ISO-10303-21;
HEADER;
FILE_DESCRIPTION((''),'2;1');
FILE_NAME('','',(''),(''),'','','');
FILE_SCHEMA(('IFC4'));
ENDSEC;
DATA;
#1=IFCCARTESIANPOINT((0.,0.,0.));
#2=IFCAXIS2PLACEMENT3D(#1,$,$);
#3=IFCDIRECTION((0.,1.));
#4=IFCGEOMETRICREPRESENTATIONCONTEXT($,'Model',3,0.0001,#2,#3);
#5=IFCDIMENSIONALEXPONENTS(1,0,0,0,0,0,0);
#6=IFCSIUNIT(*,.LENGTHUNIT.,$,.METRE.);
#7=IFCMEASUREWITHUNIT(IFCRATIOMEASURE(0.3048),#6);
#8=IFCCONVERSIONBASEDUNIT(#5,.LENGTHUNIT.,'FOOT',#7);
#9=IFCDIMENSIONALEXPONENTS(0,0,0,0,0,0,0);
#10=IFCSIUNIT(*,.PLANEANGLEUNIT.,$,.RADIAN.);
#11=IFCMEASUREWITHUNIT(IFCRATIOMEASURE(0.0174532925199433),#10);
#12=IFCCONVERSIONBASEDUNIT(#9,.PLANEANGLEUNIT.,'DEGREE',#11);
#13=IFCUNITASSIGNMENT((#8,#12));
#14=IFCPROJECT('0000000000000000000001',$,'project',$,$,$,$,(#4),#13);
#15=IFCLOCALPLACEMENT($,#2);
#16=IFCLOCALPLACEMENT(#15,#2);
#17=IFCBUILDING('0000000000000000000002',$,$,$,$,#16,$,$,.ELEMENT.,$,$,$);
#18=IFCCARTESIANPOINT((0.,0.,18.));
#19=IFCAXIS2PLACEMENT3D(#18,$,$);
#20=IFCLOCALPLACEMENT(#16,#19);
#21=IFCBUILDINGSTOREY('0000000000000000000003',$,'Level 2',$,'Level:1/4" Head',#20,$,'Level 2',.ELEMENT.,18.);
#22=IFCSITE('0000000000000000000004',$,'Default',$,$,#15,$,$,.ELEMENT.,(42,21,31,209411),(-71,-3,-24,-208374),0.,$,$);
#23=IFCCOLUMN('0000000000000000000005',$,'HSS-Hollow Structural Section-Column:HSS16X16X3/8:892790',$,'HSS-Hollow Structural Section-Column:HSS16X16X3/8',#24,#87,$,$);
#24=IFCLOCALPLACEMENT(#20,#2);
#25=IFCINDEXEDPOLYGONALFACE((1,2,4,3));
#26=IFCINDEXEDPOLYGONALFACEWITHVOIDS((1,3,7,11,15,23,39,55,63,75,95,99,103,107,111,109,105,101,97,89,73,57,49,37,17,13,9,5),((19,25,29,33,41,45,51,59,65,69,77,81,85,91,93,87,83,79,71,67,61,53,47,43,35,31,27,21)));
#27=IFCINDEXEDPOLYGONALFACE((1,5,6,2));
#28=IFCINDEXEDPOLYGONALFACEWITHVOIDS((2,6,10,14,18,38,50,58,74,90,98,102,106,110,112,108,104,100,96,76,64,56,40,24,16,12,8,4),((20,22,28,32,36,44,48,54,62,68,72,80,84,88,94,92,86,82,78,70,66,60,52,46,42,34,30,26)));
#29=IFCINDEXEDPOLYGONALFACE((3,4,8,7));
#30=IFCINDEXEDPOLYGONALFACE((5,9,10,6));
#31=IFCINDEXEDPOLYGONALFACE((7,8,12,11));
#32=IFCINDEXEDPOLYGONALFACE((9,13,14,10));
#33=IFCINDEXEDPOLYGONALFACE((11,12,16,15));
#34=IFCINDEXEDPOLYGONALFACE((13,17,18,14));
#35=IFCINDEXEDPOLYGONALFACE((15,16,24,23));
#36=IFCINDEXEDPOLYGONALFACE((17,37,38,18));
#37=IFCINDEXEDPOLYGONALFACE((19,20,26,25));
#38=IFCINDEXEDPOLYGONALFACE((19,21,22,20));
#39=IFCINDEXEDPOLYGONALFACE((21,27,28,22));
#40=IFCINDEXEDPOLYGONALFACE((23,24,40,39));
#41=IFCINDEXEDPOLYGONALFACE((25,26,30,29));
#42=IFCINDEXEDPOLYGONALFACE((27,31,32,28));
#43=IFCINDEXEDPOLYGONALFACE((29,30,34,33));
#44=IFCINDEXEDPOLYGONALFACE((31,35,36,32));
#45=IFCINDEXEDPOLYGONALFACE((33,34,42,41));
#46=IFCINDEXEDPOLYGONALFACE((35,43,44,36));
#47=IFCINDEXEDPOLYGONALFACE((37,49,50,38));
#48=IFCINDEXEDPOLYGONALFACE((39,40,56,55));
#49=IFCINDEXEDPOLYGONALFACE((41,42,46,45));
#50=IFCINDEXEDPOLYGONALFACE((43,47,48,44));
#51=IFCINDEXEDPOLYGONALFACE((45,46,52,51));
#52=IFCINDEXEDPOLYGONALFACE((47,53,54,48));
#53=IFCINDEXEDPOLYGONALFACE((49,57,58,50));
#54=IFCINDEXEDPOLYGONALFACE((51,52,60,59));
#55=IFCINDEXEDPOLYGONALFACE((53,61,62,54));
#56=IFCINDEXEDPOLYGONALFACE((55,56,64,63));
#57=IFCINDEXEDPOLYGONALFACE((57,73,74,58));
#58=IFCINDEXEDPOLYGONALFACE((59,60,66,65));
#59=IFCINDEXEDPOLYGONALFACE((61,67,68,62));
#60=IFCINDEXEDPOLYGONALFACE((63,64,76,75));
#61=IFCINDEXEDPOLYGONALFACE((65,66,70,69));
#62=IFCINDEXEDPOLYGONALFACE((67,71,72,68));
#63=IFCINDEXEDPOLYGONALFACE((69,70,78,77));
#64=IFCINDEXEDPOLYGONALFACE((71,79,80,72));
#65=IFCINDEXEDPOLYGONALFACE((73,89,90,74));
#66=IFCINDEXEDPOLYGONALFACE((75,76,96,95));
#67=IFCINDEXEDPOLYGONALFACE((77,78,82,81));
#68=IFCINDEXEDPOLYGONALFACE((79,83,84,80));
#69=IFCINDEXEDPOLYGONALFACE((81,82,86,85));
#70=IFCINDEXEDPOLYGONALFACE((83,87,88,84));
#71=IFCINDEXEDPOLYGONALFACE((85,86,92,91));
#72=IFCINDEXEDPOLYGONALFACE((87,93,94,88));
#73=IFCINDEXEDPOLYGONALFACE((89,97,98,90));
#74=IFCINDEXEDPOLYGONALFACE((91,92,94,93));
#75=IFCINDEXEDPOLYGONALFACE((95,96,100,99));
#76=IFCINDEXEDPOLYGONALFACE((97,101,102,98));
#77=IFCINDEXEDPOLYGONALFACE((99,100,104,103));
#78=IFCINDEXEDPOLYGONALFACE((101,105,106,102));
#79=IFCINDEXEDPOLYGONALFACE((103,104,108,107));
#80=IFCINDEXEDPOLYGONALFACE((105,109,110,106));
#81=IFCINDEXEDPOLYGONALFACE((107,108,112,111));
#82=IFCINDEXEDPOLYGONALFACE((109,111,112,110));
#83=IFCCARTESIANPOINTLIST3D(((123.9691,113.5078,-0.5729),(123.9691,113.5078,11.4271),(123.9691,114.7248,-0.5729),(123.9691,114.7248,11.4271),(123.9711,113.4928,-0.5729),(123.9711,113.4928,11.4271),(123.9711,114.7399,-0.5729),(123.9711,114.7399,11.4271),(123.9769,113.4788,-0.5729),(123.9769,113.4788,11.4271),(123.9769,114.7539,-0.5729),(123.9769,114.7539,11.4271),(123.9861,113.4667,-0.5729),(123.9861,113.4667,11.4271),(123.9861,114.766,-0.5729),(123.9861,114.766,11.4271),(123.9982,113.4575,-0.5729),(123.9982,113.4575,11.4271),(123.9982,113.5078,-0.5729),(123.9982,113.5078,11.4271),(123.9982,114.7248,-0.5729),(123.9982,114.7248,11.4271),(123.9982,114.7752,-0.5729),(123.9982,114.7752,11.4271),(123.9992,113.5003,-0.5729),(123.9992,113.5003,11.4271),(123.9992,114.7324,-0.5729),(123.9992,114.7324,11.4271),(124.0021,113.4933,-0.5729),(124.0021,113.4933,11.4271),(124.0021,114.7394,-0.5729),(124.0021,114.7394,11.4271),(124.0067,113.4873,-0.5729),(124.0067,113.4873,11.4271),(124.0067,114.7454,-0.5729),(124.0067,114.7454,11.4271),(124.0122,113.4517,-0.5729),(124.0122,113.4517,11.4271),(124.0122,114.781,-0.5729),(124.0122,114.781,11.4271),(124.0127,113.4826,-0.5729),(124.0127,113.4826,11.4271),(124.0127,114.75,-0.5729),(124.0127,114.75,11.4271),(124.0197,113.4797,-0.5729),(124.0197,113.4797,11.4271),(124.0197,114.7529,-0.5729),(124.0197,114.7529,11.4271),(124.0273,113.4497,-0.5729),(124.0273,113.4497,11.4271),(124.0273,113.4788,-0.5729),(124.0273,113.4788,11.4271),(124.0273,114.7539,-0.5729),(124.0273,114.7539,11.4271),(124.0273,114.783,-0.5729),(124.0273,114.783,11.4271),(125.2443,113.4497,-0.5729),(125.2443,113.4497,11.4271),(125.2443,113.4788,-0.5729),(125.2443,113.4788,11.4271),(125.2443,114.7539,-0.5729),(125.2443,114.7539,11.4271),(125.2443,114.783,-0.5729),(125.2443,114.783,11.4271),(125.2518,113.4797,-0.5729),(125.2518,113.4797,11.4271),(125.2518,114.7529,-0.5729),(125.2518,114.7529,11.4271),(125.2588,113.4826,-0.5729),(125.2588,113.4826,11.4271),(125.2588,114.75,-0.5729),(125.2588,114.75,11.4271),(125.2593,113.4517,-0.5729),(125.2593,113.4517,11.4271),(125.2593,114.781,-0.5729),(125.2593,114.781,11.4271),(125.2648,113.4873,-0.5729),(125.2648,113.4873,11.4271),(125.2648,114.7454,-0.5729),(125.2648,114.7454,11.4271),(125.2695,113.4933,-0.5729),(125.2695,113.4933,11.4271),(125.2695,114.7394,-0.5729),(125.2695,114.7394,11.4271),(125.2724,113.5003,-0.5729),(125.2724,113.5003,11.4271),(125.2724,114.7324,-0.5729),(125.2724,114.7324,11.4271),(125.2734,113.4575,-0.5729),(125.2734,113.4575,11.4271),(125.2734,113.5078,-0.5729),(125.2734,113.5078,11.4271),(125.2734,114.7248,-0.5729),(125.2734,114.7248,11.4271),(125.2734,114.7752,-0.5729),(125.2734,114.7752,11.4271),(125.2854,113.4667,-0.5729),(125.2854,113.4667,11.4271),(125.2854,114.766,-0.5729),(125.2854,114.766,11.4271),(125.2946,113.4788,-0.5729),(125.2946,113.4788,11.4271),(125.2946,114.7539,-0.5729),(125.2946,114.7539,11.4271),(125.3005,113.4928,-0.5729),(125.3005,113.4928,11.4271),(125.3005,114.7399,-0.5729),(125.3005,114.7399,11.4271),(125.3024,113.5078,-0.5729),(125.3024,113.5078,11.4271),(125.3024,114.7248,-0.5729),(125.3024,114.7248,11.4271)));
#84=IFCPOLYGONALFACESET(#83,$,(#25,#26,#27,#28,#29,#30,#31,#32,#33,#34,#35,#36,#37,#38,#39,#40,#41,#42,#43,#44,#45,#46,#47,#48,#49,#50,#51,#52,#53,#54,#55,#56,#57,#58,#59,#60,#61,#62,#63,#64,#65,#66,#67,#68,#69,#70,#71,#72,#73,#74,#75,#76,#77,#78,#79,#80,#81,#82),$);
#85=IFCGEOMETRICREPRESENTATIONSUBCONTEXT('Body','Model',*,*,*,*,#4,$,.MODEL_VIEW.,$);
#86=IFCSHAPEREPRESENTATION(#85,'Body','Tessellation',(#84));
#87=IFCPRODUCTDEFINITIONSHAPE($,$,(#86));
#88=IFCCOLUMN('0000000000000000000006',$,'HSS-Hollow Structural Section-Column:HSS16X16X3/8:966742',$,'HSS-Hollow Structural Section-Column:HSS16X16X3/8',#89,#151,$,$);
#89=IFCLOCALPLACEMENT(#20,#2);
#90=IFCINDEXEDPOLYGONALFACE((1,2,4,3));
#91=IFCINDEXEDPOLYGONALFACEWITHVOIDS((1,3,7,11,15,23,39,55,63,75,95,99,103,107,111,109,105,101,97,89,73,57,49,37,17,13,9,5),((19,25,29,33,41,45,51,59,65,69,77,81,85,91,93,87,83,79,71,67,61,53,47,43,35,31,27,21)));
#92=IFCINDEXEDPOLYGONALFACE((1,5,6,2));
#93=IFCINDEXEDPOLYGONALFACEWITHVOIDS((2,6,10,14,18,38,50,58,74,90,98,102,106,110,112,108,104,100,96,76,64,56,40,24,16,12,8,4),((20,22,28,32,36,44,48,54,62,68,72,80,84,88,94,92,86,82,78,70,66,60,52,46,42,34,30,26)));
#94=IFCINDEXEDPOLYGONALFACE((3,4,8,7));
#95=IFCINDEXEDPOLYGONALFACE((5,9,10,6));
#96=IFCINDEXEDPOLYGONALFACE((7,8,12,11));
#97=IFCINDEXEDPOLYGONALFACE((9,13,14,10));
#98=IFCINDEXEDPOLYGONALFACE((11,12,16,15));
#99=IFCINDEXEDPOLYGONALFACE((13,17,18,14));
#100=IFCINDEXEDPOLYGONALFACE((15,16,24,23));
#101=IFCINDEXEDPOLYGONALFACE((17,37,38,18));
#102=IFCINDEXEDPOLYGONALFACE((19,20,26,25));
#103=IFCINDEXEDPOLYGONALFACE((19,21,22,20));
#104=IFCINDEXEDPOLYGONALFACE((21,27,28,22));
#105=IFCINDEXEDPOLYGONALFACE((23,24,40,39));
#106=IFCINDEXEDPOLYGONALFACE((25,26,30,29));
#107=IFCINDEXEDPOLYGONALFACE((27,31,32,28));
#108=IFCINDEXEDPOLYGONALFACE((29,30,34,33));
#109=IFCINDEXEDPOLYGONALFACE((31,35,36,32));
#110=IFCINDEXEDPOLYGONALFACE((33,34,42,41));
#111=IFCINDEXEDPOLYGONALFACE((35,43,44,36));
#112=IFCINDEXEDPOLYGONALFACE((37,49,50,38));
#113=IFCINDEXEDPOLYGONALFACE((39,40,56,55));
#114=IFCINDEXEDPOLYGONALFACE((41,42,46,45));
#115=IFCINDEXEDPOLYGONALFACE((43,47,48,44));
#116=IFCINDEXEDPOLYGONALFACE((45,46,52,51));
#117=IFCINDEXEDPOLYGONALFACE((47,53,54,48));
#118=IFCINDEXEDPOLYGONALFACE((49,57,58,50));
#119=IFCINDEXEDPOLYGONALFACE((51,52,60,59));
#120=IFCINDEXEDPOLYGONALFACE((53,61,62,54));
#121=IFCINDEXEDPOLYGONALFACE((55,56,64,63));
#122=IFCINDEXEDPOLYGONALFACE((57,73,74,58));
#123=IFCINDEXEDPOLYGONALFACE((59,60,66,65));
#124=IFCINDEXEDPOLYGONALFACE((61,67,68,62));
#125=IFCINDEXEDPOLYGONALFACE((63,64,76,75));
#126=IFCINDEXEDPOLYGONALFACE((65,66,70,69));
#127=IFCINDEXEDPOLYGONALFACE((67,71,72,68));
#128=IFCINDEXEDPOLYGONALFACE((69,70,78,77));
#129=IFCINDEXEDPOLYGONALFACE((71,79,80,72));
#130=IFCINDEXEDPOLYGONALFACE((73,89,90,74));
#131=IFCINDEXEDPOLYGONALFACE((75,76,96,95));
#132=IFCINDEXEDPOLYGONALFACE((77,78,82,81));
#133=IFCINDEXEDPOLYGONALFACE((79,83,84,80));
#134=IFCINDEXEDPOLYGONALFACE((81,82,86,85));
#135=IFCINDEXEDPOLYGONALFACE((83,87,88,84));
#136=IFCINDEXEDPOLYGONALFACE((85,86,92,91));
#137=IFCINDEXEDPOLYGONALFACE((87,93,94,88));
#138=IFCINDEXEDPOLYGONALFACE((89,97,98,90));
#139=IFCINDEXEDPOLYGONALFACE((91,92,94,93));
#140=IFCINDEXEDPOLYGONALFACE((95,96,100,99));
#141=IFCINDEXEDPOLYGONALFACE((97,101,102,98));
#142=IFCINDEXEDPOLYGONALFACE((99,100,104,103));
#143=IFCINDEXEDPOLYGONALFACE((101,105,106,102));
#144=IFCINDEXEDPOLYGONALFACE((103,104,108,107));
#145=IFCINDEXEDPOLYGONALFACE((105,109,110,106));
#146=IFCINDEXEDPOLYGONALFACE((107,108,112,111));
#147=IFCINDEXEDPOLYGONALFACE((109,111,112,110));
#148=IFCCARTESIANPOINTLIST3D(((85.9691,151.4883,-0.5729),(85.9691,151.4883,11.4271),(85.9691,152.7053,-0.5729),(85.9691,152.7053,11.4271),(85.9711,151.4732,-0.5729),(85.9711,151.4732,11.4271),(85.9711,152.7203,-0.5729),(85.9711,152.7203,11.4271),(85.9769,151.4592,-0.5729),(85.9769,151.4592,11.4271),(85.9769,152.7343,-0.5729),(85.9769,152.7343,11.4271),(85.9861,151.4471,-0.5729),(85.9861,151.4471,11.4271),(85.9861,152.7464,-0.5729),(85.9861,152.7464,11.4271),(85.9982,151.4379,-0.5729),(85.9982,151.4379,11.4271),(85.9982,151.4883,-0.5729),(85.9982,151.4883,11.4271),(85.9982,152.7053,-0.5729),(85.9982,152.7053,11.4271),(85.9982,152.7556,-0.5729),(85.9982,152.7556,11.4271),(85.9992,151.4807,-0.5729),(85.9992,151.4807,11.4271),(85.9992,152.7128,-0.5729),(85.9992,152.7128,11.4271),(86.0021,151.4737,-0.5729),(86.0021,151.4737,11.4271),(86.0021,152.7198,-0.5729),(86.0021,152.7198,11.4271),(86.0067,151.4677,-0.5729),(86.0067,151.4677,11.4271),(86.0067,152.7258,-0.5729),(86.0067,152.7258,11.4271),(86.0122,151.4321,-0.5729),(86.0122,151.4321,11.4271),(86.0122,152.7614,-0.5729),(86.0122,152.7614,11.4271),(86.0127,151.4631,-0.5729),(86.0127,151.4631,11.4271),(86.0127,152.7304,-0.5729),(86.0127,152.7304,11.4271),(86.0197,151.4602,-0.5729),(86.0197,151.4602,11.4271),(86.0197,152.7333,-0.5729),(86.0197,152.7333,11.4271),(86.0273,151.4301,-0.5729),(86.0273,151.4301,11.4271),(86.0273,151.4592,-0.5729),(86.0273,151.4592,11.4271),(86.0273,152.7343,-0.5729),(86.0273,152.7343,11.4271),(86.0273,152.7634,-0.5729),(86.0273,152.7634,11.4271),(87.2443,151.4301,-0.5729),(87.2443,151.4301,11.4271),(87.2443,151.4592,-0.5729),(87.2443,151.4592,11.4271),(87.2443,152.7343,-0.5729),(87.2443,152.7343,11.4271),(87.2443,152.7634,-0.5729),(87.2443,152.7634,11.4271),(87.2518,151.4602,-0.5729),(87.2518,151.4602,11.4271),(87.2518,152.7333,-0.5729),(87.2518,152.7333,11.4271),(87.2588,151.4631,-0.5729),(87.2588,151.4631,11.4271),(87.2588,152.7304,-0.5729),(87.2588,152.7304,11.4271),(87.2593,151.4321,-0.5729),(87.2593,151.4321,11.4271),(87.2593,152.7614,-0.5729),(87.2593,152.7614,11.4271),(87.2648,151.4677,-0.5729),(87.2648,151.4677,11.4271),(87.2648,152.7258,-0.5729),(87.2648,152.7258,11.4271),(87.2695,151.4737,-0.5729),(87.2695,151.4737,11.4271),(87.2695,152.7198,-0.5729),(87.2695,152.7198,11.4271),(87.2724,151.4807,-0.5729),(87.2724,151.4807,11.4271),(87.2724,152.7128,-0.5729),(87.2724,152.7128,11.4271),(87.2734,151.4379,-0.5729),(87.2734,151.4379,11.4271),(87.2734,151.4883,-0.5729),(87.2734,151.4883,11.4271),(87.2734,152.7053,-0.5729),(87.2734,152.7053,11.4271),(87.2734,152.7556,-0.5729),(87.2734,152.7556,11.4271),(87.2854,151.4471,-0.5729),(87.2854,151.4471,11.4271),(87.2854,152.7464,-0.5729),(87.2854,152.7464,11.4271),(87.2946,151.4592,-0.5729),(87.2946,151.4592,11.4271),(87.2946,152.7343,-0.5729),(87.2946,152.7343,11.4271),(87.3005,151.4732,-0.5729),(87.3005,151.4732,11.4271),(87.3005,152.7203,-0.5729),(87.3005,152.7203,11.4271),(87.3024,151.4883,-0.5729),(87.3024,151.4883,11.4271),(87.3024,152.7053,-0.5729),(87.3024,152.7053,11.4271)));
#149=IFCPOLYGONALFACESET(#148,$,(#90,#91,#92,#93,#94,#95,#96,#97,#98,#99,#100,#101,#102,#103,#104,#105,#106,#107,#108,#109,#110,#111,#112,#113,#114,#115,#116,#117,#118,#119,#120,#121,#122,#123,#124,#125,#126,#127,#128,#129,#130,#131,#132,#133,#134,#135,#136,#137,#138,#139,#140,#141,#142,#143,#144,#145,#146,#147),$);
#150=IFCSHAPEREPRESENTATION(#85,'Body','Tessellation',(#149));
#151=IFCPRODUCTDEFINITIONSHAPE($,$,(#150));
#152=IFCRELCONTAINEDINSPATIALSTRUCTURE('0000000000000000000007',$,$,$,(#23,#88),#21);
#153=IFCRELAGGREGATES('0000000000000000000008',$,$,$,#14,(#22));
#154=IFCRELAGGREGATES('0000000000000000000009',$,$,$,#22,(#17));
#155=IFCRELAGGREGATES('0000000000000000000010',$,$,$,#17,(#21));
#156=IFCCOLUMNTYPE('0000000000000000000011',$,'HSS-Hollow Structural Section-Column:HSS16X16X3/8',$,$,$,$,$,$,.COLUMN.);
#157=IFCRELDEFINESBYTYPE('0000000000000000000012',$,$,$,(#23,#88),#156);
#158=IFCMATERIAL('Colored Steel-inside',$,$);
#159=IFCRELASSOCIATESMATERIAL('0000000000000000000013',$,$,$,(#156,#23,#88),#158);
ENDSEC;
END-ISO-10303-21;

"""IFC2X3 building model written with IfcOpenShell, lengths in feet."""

from ifc_helpers import new_model, entity, si_unit, converted_unit, direction, frame, frame_2d, origin, place, context, subcontext, project, spatial, polyline, circle_curve, parameter, trimmed, segment, composite_curve, outline, extrude, source, transform, mapped, material, type_object, type_shapes, element, save


model = new_model("IFC2X3")

# Units and contexts
model_context = context("Model", 3, precision=0.0001, world=origin(), true_north=direction((0.0, 1.0)))
body_context = subcontext(model_context, "Body", "Model", "MODEL_VIEW")
ifc_project = project(units=[converted_unit("LENGTHUNIT", "FOOT", entity("IfcRatioMeasure", 0.3048), si_unit("LENGTHUNIT", "METRE"), dimensions=[1, 0, 0, 0, 0, 0, 0]), converted_unit("PLANEANGLEUNIT", "DEGREE", entity("IfcRatioMeasure", 0.0174532925199433), si_unit("PLANEANGLEUNIT", "RADIAN"), dimensions=[0, 0, 0, 0, 0, 0, 0])], contexts=[model_context])

# Site, building, storey
site_placement = place(None, origin())
site = spatial("IfcSite", under=ifc_project, at=site_placement, Name="Default", CompositionType="ELEMENT", RefLatitude=(42, 21, 31, 209411), RefLongitude=(-71, -3, -24, -208374), RefElevation=0.0)
building_placement = place(site_placement, origin())
building = spatial("IfcBuilding", under=site, at=building_placement, CompositionType="ELEMENT")
storey_placement = place(building_placement, frame((0.0, 0.0, 18.0)))
storey = spatial("IfcBuildingStorey", under=building, at=storey_placement, Name="Level 2", ObjectType="Level:1/4\" Head", LongName="Level 2", CompositionType="ELEMENT", Elevation=18.0)

# Columns
ifc_material_1 = material(Name="Colored Steel-inside")
column_type = type_object("IfcColumnType", Name="HSS-Hollow Structural Section-Column:HSS16X16X3/8", PredefinedType="COLUMN", material=ifc_material_1)
shared_shape = source(origin(), body_context, "Body", "SweptSolid", [
    extrude(outline(composite_curve([segment(polyline([(-0.6085, -0.6667), (0.6085, -0.6667)]), True, "CONTINUOUS"), segment(trimmed(circle_curve(frame_2d((0.6085, -0.6085), x_axis=(-1.0, 0.0)), 0.0582), [parameter(90.0)], [parameter(180.0)], True, "PARAMETER"), True, "CONTINUOUS"), segment(polyline([(0.6667, -0.6085), (0.6667, 0.6085)]), True, "CONTINUOUS"), segment(trimmed(circle_curve(frame_2d((0.6085, 0.6085), x_axis=(-1.0, 0.0)), 0.0582), [parameter(180.0)], [parameter(270.0)], True, "PARAMETER"), True, "CONTINUOUS"), segment(polyline([(0.6085, 0.6667), (-0.6085, 0.6667)]), True, "CONTINUOUS"), segment(trimmed(circle_curve(frame_2d((-0.6085, 0.6085), x_axis=(-1.0, 0.0)), 0.0582), [parameter(270.0)], [parameter(360.0)], True, "PARAMETER"), True, "CONTINUOUS"), segment(polyline([(-0.6667, 0.6085), (-0.6667, -0.6085)]), True, "CONTINUOUS"), segment(trimmed(circle_curve(frame_2d((-0.6085, -0.6085), x_axis=(-1.0, 0.0)), 0.0582), [parameter(360.0)], [parameter(90.0)], True, "PARAMETER"), True, "CONTINUOUS")], self_intersect=False), holes=[composite_curve([segment(trimmed(circle_curve(frame_2d((-0.6085, -0.6085), x_axis=(-1.0, 0.0)), 0.0291), [parameter(0.0)], [parameter(90.0)], True, "PARAMETER"), False, "CONTINUOUS"), segment(polyline([(-0.6376, -0.6085), (-0.6376, 0.6085)]), True, "CONTINUOUS"), segment(trimmed(circle_curve(frame_2d((-0.6085, 0.6085), x_axis=(-1.0, 0.0)), 0.0291), [parameter(270.0)], [parameter(360.0)], True, "PARAMETER"), False, "CONTINUOUS"), segment(polyline([(-0.6085, 0.6376), (0.6085, 0.6376)]), True, "CONTINUOUS"), segment(trimmed(circle_curve(frame_2d((0.6085, 0.6085), x_axis=(-1.0, 0.0)), 0.0291), [parameter(180.0)], [parameter(270.0)], True, "PARAMETER"), False, "CONTINUOUS"), segment(polyline([(0.6376, 0.6085), (0.6376, -0.6085)]), True, "CONTINUOUS"), segment(trimmed(circle_curve(frame_2d((0.6085, -0.6085), x_axis=(-1.0, 0.0)), 0.0291), [parameter(90.0)], [parameter(180.0)], True, "PARAMETER"), False, "CONTINUOUS"), segment(polyline([(0.6085, -0.6376), (-0.6085, -0.6376)]), True, "CONTINUOUS")], self_intersect=False)]), frame((0.0, 0.0, 17.4271), z_axis=(0.0, 0.0, 1.0), x_axis=(-1.0, 0.0, 0.0)), (0.0, 0.0, 1.0), 12.0),
])
type_shapes(column_type, [shared_shape])
for number, where, name in (
    (1, (124.6358, 114.1163, -18.0), "HSS-Hollow Structural Section-Column:HSS16X16X3/8:892790"),
    (2, (86.6358, 152.0968, -18.0), "HSS-Hollow Structural Section-Column:HSS16X16X3/8:966742"),
):
    element("IfcColumn", number, at=place(storey_placement, frame(where)), inside=storey, type_object=column_type, material=ifc_material_1, Name=name, ObjectType="HSS-Hollow Structural Section-Column:HSS16X16X3/8", context=body_context, shape_type="MappedRepresentation", body=[
        mapped(shared_shape, transform((0.0, 0.0, 0.0), scale=1.0)),
    ])

save(model, "model.ifc")
